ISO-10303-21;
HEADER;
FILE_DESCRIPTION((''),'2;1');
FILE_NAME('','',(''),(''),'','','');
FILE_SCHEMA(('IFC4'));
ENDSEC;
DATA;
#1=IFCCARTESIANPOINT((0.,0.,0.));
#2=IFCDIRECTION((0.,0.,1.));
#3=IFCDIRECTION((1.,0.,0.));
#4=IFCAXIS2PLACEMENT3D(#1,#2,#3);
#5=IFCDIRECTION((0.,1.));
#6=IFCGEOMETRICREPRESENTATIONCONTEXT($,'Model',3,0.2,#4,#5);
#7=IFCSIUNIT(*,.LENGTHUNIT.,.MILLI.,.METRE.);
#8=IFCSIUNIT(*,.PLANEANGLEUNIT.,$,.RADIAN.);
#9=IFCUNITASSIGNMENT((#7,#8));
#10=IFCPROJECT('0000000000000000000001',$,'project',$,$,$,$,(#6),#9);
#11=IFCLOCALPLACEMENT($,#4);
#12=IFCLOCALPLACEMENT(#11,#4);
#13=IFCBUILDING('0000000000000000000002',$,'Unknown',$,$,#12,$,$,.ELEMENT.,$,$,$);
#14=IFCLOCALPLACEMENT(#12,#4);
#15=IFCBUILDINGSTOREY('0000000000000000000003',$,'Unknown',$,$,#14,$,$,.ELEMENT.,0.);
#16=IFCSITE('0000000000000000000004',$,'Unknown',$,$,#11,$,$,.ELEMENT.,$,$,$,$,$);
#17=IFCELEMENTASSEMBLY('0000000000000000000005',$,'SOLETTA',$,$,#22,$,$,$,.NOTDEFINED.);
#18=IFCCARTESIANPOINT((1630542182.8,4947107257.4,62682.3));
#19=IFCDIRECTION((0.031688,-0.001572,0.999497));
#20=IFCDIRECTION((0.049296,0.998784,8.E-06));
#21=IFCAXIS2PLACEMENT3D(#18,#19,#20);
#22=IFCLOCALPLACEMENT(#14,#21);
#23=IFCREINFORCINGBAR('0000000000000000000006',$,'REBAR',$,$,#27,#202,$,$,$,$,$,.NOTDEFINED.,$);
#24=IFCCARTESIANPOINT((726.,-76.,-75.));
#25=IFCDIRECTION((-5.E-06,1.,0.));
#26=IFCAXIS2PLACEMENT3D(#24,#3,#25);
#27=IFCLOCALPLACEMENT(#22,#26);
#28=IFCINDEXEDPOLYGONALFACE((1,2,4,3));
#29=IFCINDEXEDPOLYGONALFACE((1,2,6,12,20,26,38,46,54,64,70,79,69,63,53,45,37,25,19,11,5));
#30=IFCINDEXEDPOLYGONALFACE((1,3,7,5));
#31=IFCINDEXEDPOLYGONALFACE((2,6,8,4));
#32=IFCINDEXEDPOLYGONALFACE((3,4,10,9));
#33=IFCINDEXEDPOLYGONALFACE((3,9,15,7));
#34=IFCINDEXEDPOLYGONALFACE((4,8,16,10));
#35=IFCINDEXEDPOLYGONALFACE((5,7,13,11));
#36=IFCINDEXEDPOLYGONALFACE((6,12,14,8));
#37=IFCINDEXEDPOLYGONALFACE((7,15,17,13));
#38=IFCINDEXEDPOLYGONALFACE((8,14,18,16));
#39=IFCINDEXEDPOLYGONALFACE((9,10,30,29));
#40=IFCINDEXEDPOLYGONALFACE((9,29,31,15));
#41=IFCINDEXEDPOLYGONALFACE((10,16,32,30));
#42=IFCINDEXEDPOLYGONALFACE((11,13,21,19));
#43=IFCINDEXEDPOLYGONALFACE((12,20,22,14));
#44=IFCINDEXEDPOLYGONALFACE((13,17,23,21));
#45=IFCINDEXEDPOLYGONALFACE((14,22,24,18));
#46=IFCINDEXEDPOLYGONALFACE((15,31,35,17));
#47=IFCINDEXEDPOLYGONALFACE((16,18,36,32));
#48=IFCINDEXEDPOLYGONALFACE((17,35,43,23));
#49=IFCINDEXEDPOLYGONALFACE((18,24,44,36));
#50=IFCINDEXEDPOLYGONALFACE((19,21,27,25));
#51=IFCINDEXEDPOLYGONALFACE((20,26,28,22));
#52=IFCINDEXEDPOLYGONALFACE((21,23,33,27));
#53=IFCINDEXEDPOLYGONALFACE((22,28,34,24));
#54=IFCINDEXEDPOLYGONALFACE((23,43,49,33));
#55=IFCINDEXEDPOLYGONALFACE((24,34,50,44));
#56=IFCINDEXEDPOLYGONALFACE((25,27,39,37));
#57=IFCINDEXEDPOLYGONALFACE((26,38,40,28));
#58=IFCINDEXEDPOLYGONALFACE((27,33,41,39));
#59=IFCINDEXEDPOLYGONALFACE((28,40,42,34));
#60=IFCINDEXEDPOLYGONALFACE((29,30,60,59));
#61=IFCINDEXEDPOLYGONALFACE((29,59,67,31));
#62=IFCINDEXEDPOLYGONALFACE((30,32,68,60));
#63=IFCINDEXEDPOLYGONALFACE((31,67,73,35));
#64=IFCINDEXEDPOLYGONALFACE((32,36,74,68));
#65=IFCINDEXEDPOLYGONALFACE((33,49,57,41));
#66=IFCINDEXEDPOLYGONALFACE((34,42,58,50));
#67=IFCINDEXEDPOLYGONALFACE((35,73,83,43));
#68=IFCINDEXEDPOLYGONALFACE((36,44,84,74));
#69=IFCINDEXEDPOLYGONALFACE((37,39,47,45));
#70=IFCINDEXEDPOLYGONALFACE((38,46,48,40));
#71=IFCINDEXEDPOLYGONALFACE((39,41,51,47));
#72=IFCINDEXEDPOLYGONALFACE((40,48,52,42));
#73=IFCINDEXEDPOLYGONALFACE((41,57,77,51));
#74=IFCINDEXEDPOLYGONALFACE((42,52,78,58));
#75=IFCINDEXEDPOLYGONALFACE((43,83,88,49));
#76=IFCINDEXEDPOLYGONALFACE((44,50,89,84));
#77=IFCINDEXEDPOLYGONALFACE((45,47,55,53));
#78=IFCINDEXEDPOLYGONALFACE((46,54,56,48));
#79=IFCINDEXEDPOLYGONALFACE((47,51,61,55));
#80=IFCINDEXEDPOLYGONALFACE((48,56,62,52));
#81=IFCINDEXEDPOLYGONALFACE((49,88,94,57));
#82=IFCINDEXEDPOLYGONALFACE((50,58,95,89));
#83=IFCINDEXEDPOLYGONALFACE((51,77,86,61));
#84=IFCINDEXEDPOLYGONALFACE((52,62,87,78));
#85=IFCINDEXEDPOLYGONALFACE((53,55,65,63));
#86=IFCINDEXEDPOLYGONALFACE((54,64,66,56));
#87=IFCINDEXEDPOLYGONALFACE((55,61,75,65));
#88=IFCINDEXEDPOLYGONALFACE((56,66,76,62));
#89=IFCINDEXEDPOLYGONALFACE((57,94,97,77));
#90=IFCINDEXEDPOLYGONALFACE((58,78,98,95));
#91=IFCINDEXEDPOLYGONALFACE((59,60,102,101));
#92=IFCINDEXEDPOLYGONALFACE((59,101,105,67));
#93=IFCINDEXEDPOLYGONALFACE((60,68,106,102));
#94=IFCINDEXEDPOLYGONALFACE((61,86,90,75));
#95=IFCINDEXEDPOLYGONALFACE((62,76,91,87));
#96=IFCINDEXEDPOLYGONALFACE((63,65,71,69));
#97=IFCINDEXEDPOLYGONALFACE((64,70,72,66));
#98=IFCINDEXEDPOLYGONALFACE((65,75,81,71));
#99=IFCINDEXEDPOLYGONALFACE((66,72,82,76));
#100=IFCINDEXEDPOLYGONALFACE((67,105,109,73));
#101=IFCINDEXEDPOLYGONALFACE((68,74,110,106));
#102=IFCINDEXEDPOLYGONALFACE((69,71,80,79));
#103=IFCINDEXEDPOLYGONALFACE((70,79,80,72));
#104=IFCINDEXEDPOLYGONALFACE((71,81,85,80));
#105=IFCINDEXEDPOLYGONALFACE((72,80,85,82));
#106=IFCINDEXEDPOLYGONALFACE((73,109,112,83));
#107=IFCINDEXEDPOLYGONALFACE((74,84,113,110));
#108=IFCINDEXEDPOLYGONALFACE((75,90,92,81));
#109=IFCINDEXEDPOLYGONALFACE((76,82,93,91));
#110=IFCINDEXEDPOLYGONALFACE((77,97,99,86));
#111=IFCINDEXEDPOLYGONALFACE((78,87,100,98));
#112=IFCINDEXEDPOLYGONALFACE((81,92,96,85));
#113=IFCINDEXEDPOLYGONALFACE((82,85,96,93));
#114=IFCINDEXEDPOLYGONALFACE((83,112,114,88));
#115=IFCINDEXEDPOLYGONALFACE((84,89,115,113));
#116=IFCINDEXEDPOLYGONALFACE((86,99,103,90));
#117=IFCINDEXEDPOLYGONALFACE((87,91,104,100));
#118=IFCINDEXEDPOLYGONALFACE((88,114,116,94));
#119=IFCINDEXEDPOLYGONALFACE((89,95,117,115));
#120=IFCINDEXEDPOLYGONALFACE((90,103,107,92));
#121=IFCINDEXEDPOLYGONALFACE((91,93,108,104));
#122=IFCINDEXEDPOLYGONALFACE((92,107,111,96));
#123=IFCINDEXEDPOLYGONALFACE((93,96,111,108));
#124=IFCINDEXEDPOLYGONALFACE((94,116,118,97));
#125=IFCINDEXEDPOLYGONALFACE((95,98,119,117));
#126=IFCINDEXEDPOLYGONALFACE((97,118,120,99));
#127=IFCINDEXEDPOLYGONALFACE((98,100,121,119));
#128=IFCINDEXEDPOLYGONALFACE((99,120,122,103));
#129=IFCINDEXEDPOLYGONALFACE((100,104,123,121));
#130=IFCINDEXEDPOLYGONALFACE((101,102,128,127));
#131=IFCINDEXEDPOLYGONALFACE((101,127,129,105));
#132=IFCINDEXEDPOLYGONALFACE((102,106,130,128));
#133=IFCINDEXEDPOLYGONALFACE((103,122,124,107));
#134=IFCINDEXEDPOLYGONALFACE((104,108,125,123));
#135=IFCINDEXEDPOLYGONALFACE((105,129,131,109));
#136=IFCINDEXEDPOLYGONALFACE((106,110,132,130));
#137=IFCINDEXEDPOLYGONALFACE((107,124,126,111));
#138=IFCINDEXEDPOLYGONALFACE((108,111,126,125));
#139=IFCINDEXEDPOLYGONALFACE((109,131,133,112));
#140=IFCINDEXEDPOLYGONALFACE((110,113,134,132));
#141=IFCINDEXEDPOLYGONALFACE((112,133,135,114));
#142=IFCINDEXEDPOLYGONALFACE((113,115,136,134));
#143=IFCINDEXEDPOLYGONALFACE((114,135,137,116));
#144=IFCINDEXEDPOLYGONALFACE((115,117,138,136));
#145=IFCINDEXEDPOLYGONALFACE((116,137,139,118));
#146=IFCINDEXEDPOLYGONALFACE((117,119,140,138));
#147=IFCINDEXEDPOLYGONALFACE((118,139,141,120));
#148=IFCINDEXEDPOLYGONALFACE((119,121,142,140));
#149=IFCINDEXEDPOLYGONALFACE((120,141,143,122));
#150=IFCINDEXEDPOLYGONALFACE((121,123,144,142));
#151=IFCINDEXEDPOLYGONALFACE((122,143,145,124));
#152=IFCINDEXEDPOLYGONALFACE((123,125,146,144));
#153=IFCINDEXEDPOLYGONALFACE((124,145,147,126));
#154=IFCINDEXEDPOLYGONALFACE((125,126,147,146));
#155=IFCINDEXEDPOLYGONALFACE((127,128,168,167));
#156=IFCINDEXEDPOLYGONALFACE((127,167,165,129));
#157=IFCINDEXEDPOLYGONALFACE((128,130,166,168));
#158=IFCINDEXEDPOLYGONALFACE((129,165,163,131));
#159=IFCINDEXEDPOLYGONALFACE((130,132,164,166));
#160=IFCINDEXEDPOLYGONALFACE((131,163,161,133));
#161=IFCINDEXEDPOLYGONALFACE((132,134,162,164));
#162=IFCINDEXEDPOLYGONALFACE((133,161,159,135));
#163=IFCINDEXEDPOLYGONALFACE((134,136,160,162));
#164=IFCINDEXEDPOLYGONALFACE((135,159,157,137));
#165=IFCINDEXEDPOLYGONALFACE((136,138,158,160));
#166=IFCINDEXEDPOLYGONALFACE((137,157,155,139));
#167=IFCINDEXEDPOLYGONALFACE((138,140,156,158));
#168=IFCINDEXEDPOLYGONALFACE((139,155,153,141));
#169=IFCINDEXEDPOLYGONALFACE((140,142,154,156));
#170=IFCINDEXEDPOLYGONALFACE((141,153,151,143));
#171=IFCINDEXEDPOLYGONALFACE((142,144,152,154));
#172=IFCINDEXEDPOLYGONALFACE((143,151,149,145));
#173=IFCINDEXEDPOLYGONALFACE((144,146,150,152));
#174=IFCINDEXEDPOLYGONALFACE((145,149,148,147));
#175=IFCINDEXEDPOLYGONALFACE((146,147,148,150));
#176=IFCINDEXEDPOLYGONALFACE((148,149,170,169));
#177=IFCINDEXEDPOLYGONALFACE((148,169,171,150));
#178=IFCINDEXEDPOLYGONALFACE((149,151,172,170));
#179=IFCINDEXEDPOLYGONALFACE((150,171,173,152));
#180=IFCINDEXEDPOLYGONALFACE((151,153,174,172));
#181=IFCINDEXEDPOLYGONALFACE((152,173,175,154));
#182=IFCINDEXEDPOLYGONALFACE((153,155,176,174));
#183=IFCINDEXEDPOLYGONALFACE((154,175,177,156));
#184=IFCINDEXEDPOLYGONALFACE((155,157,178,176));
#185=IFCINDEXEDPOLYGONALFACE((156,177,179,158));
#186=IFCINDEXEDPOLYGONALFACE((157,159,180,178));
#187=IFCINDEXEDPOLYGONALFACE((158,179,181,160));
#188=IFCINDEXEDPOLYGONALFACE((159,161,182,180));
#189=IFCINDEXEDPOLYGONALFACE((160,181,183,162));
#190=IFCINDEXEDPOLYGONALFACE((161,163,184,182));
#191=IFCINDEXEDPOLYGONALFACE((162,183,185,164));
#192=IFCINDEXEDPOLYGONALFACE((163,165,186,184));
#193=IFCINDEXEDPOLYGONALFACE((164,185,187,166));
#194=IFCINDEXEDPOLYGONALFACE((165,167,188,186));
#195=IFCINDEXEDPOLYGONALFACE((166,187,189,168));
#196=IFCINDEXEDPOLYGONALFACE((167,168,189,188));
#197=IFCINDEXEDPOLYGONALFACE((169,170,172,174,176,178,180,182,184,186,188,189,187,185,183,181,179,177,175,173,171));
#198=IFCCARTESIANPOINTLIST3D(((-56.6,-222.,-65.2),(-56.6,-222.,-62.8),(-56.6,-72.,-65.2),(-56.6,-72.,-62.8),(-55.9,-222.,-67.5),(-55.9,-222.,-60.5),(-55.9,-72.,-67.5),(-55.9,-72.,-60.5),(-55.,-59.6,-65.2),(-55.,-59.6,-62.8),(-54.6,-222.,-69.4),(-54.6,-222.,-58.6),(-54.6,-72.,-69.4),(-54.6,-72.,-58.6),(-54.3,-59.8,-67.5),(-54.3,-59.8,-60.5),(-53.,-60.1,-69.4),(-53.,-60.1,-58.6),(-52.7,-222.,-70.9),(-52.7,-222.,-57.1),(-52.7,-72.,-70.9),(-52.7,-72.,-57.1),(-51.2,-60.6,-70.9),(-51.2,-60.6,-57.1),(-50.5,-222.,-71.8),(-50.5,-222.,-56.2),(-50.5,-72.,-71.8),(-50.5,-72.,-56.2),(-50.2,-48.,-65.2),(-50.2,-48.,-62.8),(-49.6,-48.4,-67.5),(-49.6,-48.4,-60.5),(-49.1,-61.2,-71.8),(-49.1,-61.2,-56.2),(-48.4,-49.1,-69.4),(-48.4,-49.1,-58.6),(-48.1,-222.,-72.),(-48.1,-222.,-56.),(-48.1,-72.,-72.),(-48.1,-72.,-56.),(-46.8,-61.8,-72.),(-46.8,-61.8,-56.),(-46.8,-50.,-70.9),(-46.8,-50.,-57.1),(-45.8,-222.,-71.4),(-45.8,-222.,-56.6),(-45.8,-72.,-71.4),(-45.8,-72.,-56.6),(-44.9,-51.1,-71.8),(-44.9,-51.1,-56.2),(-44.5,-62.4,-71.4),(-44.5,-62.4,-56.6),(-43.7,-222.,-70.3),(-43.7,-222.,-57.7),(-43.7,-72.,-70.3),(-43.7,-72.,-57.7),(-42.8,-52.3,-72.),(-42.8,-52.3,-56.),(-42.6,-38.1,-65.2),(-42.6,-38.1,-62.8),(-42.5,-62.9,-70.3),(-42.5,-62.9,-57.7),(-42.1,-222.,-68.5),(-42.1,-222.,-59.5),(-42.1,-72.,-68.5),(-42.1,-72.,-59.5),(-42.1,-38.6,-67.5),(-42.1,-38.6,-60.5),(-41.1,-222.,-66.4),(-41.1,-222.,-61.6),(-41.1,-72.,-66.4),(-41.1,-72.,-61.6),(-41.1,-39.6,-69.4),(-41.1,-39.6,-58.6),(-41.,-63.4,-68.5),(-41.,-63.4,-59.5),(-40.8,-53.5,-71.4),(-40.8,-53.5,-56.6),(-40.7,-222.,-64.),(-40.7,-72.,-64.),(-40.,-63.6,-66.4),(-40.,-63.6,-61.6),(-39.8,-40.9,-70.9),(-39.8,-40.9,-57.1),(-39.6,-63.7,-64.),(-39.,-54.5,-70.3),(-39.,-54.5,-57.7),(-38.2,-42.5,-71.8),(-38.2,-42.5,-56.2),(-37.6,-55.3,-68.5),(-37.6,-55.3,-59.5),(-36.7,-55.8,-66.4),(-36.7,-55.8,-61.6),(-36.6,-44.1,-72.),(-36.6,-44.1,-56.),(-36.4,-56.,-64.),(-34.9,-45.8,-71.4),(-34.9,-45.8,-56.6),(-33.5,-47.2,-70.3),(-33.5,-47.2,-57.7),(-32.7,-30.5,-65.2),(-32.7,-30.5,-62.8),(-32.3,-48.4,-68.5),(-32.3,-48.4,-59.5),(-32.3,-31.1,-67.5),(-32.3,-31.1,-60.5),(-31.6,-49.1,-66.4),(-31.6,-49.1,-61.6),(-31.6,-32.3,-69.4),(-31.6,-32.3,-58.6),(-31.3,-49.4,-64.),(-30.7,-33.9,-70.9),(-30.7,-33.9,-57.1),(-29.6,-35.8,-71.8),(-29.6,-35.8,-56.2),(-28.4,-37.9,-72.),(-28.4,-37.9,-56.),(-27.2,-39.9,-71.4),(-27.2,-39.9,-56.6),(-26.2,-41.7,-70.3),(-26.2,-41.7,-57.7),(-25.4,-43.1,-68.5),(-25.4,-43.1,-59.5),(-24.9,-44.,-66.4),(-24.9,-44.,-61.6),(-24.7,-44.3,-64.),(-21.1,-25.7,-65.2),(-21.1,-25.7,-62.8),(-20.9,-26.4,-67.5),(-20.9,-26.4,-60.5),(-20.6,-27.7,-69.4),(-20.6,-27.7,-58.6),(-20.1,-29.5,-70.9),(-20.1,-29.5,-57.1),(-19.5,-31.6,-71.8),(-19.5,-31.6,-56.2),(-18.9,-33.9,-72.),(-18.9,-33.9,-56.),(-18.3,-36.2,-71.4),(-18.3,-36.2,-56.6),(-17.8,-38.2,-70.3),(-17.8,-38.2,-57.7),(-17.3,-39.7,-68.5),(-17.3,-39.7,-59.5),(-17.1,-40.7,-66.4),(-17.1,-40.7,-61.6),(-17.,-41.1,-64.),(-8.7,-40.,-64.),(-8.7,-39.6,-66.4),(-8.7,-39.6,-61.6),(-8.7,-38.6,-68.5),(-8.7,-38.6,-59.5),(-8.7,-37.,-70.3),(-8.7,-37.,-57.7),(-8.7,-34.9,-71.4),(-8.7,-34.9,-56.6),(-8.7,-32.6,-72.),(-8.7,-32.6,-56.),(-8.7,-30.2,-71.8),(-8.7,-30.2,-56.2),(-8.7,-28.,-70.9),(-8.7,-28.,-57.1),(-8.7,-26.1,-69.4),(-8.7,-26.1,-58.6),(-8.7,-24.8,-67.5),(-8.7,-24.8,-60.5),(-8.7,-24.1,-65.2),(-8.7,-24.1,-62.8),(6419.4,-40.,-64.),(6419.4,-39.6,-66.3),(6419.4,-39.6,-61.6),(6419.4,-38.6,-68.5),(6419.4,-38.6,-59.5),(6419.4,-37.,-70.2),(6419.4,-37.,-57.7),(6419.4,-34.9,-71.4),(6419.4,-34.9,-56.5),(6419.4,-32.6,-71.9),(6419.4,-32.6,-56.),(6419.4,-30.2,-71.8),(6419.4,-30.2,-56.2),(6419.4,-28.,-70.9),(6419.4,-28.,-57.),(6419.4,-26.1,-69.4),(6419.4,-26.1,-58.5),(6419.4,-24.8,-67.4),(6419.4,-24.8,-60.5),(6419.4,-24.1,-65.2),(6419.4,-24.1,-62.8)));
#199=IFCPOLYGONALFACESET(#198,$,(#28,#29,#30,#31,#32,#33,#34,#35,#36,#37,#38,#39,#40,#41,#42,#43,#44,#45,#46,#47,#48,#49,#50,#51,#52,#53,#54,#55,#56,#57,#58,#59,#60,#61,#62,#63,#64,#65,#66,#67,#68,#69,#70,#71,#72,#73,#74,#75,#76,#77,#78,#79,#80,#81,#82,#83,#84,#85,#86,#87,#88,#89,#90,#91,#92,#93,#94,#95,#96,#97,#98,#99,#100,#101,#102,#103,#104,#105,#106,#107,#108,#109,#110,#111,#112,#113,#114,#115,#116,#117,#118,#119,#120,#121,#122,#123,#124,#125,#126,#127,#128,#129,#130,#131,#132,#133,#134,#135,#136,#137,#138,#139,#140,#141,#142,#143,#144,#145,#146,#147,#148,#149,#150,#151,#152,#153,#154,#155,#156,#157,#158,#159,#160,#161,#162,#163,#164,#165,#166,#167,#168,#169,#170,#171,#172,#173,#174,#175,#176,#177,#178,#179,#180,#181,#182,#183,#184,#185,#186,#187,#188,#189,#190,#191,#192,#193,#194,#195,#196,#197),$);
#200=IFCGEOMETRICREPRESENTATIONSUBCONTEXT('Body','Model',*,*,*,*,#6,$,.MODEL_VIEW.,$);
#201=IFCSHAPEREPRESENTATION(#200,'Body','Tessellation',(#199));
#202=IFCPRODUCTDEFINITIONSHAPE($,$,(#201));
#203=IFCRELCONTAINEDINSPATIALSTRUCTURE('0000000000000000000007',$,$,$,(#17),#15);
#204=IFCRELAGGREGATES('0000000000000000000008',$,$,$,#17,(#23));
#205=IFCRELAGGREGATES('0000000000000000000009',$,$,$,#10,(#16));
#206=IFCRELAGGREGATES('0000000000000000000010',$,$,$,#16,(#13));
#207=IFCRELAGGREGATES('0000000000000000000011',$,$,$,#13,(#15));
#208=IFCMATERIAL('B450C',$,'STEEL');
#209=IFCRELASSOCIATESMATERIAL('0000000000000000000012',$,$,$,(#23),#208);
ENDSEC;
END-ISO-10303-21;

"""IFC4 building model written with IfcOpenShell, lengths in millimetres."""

from ifc_helpers import new_model, entity, si_unit, direction, frame, origin_with_axes, place, context, subcontext, project, spatial, material, element, aggregate, save


model = new_model("IFC4")

# Units and contexts
model_context = context("Model", 3, precision=0.2, world=origin_with_axes(), true_north=direction((0.0, 1.0)))
body_context = subcontext(model_context, "Body", "Model", "MODEL_VIEW")
ifc_project = project(units=[si_unit("LENGTHUNIT", "METRE", prefix="MILLI"), si_unit("PLANEANGLEUNIT", "RADIAN")], contexts=[model_context])

# Site, building, storey
site_placement = place(None, origin_with_axes())
site = spatial("IfcSite", under=ifc_project, at=site_placement, Name="Unknown", CompositionType="ELEMENT")
building_placement = place(site_placement, origin_with_axes())
building = spatial("IfcBuilding", under=site, at=building_placement, Name="Unknown", CompositionType="ELEMENT")
storey_placement = place(building_placement, origin_with_axes())
storey = spatial("IfcBuildingStorey", under=building, at=storey_placement, Name="Unknown", CompositionType="ELEMENT", Elevation=0.0)

# Element assembly, reinforcing bar
ifc_material = material(Name="B450C", Category="STEEL")
assembly_1_placement = place(storey_placement, frame((1630542182.8, 4947107257.4, 62682.3), z_axis=(0.031688, -0.001572, 0.999497), x_axis=(0.049296, 0.998784, 0.000008)))
assembly_1 = element("IfcElementAssembly", 1, at=assembly_1_placement, inside=storey, Name="SOLETTA", PredefinedType="NOTDEFINED")
reinforcing_bar_1_placement = place(assembly_1_placement, frame((726.0, -76.0, -75.0), z_axis=(1.0, 0.0, 0.0), x_axis=(-0.000005, 1.0, 0.0)))
reinforcing_bar_1 = element("IfcReinforcingBar", 2, at=reinforcing_bar_1_placement, material=ifc_material, Name="REBAR", PredefinedType="NOTDEFINED", context=body_context, shape_type="AdvancedSweptSolid", body=[
    entity("IfcSweptDiskSolid", entity("IfcIndexedPolyCurve", entity("IfcCartesianPointList3D", [[-48.7, -222.0, -64.0], [-48.7, -72.0, -64.0], [-37.0, -43.7, -64.0], [-8.7, -32.0, -64.0], [6419.4, -32.0, -64.0]]), [entity("IfcLineIndex", [1, 2]), entity("IfcArcIndex", [2, 3, 4]), entity("IfcLineIndex", [4, 5])]), 8.0),
])
aggregate(assembly_1, [reinforcing_bar_1])

save(model, "model.ifc")
